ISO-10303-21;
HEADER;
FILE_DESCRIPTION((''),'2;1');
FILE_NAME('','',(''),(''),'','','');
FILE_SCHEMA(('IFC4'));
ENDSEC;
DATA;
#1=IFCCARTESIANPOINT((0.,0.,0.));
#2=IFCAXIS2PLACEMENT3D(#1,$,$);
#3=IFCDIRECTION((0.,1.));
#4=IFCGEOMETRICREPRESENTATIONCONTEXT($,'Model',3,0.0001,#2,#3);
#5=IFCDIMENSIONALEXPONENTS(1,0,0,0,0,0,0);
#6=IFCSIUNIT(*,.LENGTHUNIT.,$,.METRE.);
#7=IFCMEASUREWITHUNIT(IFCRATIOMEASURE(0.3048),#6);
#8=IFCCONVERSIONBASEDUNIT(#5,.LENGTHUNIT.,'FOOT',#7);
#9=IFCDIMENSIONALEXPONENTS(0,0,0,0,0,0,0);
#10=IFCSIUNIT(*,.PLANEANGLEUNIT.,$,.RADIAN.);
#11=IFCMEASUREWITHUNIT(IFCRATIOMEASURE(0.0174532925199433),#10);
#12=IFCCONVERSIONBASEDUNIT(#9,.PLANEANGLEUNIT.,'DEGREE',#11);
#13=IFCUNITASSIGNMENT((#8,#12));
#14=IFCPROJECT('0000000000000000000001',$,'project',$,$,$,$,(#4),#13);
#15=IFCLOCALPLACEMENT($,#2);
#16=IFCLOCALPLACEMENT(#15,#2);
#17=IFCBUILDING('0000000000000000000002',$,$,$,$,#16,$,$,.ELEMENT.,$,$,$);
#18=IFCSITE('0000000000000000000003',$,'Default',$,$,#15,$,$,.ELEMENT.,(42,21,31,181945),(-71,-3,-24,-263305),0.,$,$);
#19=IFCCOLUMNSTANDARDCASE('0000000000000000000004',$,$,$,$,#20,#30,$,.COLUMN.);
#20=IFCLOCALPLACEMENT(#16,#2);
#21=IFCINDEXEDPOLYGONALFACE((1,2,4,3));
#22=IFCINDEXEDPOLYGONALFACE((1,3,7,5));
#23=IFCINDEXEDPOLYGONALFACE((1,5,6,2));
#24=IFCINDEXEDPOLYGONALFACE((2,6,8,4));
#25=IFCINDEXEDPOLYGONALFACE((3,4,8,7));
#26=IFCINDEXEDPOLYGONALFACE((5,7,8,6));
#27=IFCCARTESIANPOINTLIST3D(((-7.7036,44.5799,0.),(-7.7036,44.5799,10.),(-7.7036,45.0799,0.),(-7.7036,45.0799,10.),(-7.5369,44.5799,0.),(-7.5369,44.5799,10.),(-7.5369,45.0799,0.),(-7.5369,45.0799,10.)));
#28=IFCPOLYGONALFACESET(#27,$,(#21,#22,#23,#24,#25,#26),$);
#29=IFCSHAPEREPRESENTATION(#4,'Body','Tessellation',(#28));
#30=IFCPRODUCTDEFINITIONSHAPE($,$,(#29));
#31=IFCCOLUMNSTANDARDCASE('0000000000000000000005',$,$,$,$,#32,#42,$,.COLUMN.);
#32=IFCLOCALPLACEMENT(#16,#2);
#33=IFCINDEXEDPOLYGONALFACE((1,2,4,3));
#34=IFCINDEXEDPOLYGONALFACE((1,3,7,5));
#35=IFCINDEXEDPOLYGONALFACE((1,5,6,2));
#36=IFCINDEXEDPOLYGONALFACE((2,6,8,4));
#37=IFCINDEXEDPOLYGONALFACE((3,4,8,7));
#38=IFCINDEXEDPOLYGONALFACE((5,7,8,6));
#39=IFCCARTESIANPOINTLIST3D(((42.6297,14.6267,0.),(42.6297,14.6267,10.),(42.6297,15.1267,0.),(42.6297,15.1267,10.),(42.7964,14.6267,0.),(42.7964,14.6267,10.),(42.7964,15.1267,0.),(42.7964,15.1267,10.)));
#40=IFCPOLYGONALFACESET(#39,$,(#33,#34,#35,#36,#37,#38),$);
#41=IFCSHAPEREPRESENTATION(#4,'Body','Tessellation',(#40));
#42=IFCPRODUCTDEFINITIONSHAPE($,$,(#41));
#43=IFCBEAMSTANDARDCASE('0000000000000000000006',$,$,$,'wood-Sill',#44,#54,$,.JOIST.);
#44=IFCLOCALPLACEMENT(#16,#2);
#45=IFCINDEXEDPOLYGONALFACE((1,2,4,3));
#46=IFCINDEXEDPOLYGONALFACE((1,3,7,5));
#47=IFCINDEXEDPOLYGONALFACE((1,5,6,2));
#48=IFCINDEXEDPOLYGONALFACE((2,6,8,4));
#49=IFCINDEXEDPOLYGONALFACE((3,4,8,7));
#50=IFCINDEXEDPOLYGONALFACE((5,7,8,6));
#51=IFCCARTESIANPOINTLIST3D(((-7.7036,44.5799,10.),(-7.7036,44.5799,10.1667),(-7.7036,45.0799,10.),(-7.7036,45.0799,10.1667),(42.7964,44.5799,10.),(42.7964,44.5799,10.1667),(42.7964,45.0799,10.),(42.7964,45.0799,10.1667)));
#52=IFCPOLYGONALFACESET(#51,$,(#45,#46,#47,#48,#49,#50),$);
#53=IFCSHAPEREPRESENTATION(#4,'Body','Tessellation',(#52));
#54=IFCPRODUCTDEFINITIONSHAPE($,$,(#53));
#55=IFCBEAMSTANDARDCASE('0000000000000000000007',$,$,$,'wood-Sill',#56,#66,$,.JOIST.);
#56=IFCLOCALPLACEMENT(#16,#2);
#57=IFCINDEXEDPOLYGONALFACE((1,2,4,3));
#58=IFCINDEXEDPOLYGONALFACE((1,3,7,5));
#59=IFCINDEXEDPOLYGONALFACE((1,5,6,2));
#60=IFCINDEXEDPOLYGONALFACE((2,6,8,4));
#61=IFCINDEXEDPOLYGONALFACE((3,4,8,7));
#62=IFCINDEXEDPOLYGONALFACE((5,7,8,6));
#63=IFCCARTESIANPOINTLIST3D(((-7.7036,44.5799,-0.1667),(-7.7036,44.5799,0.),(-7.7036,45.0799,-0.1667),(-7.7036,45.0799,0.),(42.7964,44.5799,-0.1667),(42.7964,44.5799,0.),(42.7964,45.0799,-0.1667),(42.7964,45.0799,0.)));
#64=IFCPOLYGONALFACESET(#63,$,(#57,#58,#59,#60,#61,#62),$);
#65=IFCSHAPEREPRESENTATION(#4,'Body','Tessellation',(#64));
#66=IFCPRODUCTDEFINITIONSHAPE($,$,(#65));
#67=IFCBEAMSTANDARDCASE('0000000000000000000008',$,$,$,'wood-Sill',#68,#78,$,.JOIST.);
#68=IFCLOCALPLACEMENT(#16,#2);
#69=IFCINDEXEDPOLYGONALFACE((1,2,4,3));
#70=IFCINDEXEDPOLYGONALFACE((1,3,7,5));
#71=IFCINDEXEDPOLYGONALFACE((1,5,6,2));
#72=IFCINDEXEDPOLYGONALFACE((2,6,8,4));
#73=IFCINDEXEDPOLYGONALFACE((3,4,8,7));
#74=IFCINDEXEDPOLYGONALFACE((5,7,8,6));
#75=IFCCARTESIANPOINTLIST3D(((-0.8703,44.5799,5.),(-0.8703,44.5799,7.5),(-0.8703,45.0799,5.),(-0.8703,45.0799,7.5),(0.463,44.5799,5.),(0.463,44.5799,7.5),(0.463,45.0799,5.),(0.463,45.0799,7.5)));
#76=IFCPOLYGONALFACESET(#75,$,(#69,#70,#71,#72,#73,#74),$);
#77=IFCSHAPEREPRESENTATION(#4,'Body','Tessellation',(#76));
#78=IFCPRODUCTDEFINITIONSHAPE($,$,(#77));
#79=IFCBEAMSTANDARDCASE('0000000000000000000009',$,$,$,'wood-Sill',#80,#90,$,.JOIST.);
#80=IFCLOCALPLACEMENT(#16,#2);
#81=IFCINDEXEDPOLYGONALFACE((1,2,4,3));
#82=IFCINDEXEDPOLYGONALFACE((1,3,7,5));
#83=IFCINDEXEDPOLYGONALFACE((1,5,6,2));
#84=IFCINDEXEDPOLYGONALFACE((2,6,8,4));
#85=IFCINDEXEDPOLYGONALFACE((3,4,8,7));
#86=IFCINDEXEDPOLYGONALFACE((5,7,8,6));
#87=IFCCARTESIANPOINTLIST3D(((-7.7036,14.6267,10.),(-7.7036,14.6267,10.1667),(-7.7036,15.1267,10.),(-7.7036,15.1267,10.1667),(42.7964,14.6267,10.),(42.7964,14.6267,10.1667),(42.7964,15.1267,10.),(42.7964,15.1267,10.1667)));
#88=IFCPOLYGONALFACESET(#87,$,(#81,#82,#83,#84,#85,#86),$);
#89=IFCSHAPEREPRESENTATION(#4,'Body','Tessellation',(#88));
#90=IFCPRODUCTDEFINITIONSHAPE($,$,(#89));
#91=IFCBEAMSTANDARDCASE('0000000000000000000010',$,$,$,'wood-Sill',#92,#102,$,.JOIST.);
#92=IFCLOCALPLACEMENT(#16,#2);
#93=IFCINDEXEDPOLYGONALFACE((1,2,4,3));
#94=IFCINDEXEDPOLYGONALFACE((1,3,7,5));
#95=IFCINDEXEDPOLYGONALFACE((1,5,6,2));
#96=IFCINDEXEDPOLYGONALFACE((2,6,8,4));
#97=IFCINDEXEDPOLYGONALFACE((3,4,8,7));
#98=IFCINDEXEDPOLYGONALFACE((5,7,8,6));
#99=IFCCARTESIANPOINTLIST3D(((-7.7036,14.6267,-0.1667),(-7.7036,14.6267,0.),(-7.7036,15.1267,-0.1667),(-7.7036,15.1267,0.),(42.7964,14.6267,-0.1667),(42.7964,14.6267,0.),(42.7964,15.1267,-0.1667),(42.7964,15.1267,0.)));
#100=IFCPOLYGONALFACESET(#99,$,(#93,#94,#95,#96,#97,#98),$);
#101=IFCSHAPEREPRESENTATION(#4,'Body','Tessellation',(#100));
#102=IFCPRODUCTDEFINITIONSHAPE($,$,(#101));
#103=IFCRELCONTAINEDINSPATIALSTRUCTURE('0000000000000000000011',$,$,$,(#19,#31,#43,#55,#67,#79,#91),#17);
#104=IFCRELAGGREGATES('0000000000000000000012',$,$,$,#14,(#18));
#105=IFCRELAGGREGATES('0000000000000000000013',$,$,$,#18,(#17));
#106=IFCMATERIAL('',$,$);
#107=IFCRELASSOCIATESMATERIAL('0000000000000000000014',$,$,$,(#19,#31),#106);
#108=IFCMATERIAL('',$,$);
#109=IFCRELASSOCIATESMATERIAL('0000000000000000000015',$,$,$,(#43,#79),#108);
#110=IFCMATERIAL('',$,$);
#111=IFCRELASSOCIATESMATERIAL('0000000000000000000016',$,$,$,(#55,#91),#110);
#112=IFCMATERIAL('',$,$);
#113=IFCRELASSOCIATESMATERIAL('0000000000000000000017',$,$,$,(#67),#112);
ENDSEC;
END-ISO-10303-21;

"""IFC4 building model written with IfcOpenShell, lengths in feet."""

from ifc_helpers import new_model, entity, si_unit, converted_unit, direction, frame, origin, place, context, project, spatial, rectangle, extrude, material, element, save


model = new_model("IFC4")

# Units and contexts
model_context = context("Model", 3, precision=0.0001, world=origin(), true_north=direction((0.0, 1.0)))
ifc_project = project(units=[converted_unit("LENGTHUNIT", "FOOT", entity("IfcRatioMeasure", 0.3048), si_unit("LENGTHUNIT", "METRE"), dimensions=[1, 0, 0, 0, 0, 0, 0]), converted_unit("PLANEANGLEUNIT", "DEGREE", entity("IfcRatioMeasure", 0.0174532925199433), si_unit("PLANEANGLEUNIT", "RADIAN"), dimensions=[0, 0, 0, 0, 0, 0, 0])], contexts=[model_context])

# Site, building
site_placement = place(None, origin())
site = spatial("IfcSite", under=ifc_project, at=site_placement, Name="Default", CompositionType="ELEMENT", RefLatitude=(42, 21, 31, 181945), RefLongitude=(-71, -3, -24, -263305), RefElevation=0.0)
building_placement = place(site_placement, origin())
building = spatial("IfcBuilding", under=site, at=building_placement, CompositionType="ELEMENT")

# Columns
ifc_material_1 = material(Name="")
placement_1 = place(building_placement, origin())
placement_2 = place(placement_1, frame((-7.7036, 44.8299, 0.0)))
for number, where, z_axis, x_axis in (
    (1, (0.0833, 0.0, 0.0), (0.0, 0.0, 1.0), (1.0, 0.0, 0.0)),
):
    element("IfcColumnStandardCase", number, at=place(placement_2, frame(where, z_axis=z_axis, x_axis=x_axis)), inside=building, material=ifc_material_1, PredefinedType="COLUMN", context=model_context, shape_type="SweptSolid", body=[
        extrude(rectangle(XDim=0.1667, YDim=0.5), origin(), (0.0, 0.0, 1.0), 10.0),
    ])
placement_3 = place(placement_1, frame((42.7964, 14.8767, 0.0), z_axis=(0.0, 0.0, 1.0), x_axis=(-1.0, 0.0, 0.0)))
for number, where, z_axis, x_axis in (
    (2, (0.0833, 0.0, 0.0), (0.0, 0.0, 1.0), (1.0, 0.0, 0.0)),
):
    element("IfcColumnStandardCase", number, at=place(placement_3, frame(where, z_axis=z_axis, x_axis=x_axis)), inside=building, material=ifc_material_1, PredefinedType="COLUMN", context=model_context, shape_type="SweptSolid", body=[
        extrude(rectangle(XDim=0.1667, YDim=0.5), origin(), (0.0, 0.0, 1.0), 10.0),
    ])

# Beams
ifc_material_2 = material(Name="")
beam_1_placement = place(placement_2, frame((25.25, 0.0, 10.0)))
element("IfcBeamStandardCase", 3, at=beam_1_placement, inside=building, material=ifc_material_2, ObjectType="wood-Sill", PredefinedType="JOIST", context=model_context, shape_type="SweptSolid", body=[
    extrude(rectangle(XDim=50.5, YDim=0.5), origin(), (0.0, 0.0, 1.0), 0.1667),
])
ifc_material_3 = material(Name="")
beam_2_placement = place(placement_2, frame((25.25, 0.0, -0.1667)))
element("IfcBeamStandardCase", 4, at=beam_2_placement, inside=building, material=ifc_material_3, ObjectType="wood-Sill", PredefinedType="JOIST", context=model_context, shape_type="SweptSolid", body=[
    extrude(rectangle(XDim=50.5, YDim=0.5), origin(), (0.0, 0.0, 1.0), 0.1667),
])
ifc_material_4 = material(Name="")
beam_3_placement = place(placement_2, frame((7.5, 0.0, 5.0)))
element("IfcBeamStandardCase", 5, at=beam_3_placement, inside=building, material=ifc_material_4, ObjectType="wood-Sill", PredefinedType="JOIST", context=model_context, shape_type="SweptSolid", body=[
    extrude(rectangle(XDim=1.3333, YDim=0.5), origin(), (0.0, 0.0, 1.0), 2.5),
])
beam_4_placement = place(placement_3, frame((25.25, 0.0, 10.0), z_axis=(0.0, 0.0, 1.0), x_axis=(-1.0, 0.0, 0.0)))
element("IfcBeamStandardCase", 6, at=beam_4_placement, inside=building, material=ifc_material_2, ObjectType="wood-Sill", PredefinedType="JOIST", context=model_context, shape_type="SweptSolid", body=[
    extrude(rectangle(XDim=50.5, YDim=0.5), origin(), (0.0, 0.0, 1.0), 0.1667),
])
beam_5_placement = place(placement_3, frame((25.25, 0.0, -0.1667), z_axis=(0.0, 0.0, 1.0), x_axis=(-1.0, 0.0, 0.0)))
element("IfcBeamStandardCase", 7, at=beam_5_placement, inside=building, material=ifc_material_3, ObjectType="wood-Sill", PredefinedType="JOIST", context=model_context, shape_type="SweptSolid", body=[
    extrude(rectangle(XDim=50.5, YDim=0.5), origin(), (0.0, 0.0, 1.0), 0.1667),
])

save(model, "model.ifc")
